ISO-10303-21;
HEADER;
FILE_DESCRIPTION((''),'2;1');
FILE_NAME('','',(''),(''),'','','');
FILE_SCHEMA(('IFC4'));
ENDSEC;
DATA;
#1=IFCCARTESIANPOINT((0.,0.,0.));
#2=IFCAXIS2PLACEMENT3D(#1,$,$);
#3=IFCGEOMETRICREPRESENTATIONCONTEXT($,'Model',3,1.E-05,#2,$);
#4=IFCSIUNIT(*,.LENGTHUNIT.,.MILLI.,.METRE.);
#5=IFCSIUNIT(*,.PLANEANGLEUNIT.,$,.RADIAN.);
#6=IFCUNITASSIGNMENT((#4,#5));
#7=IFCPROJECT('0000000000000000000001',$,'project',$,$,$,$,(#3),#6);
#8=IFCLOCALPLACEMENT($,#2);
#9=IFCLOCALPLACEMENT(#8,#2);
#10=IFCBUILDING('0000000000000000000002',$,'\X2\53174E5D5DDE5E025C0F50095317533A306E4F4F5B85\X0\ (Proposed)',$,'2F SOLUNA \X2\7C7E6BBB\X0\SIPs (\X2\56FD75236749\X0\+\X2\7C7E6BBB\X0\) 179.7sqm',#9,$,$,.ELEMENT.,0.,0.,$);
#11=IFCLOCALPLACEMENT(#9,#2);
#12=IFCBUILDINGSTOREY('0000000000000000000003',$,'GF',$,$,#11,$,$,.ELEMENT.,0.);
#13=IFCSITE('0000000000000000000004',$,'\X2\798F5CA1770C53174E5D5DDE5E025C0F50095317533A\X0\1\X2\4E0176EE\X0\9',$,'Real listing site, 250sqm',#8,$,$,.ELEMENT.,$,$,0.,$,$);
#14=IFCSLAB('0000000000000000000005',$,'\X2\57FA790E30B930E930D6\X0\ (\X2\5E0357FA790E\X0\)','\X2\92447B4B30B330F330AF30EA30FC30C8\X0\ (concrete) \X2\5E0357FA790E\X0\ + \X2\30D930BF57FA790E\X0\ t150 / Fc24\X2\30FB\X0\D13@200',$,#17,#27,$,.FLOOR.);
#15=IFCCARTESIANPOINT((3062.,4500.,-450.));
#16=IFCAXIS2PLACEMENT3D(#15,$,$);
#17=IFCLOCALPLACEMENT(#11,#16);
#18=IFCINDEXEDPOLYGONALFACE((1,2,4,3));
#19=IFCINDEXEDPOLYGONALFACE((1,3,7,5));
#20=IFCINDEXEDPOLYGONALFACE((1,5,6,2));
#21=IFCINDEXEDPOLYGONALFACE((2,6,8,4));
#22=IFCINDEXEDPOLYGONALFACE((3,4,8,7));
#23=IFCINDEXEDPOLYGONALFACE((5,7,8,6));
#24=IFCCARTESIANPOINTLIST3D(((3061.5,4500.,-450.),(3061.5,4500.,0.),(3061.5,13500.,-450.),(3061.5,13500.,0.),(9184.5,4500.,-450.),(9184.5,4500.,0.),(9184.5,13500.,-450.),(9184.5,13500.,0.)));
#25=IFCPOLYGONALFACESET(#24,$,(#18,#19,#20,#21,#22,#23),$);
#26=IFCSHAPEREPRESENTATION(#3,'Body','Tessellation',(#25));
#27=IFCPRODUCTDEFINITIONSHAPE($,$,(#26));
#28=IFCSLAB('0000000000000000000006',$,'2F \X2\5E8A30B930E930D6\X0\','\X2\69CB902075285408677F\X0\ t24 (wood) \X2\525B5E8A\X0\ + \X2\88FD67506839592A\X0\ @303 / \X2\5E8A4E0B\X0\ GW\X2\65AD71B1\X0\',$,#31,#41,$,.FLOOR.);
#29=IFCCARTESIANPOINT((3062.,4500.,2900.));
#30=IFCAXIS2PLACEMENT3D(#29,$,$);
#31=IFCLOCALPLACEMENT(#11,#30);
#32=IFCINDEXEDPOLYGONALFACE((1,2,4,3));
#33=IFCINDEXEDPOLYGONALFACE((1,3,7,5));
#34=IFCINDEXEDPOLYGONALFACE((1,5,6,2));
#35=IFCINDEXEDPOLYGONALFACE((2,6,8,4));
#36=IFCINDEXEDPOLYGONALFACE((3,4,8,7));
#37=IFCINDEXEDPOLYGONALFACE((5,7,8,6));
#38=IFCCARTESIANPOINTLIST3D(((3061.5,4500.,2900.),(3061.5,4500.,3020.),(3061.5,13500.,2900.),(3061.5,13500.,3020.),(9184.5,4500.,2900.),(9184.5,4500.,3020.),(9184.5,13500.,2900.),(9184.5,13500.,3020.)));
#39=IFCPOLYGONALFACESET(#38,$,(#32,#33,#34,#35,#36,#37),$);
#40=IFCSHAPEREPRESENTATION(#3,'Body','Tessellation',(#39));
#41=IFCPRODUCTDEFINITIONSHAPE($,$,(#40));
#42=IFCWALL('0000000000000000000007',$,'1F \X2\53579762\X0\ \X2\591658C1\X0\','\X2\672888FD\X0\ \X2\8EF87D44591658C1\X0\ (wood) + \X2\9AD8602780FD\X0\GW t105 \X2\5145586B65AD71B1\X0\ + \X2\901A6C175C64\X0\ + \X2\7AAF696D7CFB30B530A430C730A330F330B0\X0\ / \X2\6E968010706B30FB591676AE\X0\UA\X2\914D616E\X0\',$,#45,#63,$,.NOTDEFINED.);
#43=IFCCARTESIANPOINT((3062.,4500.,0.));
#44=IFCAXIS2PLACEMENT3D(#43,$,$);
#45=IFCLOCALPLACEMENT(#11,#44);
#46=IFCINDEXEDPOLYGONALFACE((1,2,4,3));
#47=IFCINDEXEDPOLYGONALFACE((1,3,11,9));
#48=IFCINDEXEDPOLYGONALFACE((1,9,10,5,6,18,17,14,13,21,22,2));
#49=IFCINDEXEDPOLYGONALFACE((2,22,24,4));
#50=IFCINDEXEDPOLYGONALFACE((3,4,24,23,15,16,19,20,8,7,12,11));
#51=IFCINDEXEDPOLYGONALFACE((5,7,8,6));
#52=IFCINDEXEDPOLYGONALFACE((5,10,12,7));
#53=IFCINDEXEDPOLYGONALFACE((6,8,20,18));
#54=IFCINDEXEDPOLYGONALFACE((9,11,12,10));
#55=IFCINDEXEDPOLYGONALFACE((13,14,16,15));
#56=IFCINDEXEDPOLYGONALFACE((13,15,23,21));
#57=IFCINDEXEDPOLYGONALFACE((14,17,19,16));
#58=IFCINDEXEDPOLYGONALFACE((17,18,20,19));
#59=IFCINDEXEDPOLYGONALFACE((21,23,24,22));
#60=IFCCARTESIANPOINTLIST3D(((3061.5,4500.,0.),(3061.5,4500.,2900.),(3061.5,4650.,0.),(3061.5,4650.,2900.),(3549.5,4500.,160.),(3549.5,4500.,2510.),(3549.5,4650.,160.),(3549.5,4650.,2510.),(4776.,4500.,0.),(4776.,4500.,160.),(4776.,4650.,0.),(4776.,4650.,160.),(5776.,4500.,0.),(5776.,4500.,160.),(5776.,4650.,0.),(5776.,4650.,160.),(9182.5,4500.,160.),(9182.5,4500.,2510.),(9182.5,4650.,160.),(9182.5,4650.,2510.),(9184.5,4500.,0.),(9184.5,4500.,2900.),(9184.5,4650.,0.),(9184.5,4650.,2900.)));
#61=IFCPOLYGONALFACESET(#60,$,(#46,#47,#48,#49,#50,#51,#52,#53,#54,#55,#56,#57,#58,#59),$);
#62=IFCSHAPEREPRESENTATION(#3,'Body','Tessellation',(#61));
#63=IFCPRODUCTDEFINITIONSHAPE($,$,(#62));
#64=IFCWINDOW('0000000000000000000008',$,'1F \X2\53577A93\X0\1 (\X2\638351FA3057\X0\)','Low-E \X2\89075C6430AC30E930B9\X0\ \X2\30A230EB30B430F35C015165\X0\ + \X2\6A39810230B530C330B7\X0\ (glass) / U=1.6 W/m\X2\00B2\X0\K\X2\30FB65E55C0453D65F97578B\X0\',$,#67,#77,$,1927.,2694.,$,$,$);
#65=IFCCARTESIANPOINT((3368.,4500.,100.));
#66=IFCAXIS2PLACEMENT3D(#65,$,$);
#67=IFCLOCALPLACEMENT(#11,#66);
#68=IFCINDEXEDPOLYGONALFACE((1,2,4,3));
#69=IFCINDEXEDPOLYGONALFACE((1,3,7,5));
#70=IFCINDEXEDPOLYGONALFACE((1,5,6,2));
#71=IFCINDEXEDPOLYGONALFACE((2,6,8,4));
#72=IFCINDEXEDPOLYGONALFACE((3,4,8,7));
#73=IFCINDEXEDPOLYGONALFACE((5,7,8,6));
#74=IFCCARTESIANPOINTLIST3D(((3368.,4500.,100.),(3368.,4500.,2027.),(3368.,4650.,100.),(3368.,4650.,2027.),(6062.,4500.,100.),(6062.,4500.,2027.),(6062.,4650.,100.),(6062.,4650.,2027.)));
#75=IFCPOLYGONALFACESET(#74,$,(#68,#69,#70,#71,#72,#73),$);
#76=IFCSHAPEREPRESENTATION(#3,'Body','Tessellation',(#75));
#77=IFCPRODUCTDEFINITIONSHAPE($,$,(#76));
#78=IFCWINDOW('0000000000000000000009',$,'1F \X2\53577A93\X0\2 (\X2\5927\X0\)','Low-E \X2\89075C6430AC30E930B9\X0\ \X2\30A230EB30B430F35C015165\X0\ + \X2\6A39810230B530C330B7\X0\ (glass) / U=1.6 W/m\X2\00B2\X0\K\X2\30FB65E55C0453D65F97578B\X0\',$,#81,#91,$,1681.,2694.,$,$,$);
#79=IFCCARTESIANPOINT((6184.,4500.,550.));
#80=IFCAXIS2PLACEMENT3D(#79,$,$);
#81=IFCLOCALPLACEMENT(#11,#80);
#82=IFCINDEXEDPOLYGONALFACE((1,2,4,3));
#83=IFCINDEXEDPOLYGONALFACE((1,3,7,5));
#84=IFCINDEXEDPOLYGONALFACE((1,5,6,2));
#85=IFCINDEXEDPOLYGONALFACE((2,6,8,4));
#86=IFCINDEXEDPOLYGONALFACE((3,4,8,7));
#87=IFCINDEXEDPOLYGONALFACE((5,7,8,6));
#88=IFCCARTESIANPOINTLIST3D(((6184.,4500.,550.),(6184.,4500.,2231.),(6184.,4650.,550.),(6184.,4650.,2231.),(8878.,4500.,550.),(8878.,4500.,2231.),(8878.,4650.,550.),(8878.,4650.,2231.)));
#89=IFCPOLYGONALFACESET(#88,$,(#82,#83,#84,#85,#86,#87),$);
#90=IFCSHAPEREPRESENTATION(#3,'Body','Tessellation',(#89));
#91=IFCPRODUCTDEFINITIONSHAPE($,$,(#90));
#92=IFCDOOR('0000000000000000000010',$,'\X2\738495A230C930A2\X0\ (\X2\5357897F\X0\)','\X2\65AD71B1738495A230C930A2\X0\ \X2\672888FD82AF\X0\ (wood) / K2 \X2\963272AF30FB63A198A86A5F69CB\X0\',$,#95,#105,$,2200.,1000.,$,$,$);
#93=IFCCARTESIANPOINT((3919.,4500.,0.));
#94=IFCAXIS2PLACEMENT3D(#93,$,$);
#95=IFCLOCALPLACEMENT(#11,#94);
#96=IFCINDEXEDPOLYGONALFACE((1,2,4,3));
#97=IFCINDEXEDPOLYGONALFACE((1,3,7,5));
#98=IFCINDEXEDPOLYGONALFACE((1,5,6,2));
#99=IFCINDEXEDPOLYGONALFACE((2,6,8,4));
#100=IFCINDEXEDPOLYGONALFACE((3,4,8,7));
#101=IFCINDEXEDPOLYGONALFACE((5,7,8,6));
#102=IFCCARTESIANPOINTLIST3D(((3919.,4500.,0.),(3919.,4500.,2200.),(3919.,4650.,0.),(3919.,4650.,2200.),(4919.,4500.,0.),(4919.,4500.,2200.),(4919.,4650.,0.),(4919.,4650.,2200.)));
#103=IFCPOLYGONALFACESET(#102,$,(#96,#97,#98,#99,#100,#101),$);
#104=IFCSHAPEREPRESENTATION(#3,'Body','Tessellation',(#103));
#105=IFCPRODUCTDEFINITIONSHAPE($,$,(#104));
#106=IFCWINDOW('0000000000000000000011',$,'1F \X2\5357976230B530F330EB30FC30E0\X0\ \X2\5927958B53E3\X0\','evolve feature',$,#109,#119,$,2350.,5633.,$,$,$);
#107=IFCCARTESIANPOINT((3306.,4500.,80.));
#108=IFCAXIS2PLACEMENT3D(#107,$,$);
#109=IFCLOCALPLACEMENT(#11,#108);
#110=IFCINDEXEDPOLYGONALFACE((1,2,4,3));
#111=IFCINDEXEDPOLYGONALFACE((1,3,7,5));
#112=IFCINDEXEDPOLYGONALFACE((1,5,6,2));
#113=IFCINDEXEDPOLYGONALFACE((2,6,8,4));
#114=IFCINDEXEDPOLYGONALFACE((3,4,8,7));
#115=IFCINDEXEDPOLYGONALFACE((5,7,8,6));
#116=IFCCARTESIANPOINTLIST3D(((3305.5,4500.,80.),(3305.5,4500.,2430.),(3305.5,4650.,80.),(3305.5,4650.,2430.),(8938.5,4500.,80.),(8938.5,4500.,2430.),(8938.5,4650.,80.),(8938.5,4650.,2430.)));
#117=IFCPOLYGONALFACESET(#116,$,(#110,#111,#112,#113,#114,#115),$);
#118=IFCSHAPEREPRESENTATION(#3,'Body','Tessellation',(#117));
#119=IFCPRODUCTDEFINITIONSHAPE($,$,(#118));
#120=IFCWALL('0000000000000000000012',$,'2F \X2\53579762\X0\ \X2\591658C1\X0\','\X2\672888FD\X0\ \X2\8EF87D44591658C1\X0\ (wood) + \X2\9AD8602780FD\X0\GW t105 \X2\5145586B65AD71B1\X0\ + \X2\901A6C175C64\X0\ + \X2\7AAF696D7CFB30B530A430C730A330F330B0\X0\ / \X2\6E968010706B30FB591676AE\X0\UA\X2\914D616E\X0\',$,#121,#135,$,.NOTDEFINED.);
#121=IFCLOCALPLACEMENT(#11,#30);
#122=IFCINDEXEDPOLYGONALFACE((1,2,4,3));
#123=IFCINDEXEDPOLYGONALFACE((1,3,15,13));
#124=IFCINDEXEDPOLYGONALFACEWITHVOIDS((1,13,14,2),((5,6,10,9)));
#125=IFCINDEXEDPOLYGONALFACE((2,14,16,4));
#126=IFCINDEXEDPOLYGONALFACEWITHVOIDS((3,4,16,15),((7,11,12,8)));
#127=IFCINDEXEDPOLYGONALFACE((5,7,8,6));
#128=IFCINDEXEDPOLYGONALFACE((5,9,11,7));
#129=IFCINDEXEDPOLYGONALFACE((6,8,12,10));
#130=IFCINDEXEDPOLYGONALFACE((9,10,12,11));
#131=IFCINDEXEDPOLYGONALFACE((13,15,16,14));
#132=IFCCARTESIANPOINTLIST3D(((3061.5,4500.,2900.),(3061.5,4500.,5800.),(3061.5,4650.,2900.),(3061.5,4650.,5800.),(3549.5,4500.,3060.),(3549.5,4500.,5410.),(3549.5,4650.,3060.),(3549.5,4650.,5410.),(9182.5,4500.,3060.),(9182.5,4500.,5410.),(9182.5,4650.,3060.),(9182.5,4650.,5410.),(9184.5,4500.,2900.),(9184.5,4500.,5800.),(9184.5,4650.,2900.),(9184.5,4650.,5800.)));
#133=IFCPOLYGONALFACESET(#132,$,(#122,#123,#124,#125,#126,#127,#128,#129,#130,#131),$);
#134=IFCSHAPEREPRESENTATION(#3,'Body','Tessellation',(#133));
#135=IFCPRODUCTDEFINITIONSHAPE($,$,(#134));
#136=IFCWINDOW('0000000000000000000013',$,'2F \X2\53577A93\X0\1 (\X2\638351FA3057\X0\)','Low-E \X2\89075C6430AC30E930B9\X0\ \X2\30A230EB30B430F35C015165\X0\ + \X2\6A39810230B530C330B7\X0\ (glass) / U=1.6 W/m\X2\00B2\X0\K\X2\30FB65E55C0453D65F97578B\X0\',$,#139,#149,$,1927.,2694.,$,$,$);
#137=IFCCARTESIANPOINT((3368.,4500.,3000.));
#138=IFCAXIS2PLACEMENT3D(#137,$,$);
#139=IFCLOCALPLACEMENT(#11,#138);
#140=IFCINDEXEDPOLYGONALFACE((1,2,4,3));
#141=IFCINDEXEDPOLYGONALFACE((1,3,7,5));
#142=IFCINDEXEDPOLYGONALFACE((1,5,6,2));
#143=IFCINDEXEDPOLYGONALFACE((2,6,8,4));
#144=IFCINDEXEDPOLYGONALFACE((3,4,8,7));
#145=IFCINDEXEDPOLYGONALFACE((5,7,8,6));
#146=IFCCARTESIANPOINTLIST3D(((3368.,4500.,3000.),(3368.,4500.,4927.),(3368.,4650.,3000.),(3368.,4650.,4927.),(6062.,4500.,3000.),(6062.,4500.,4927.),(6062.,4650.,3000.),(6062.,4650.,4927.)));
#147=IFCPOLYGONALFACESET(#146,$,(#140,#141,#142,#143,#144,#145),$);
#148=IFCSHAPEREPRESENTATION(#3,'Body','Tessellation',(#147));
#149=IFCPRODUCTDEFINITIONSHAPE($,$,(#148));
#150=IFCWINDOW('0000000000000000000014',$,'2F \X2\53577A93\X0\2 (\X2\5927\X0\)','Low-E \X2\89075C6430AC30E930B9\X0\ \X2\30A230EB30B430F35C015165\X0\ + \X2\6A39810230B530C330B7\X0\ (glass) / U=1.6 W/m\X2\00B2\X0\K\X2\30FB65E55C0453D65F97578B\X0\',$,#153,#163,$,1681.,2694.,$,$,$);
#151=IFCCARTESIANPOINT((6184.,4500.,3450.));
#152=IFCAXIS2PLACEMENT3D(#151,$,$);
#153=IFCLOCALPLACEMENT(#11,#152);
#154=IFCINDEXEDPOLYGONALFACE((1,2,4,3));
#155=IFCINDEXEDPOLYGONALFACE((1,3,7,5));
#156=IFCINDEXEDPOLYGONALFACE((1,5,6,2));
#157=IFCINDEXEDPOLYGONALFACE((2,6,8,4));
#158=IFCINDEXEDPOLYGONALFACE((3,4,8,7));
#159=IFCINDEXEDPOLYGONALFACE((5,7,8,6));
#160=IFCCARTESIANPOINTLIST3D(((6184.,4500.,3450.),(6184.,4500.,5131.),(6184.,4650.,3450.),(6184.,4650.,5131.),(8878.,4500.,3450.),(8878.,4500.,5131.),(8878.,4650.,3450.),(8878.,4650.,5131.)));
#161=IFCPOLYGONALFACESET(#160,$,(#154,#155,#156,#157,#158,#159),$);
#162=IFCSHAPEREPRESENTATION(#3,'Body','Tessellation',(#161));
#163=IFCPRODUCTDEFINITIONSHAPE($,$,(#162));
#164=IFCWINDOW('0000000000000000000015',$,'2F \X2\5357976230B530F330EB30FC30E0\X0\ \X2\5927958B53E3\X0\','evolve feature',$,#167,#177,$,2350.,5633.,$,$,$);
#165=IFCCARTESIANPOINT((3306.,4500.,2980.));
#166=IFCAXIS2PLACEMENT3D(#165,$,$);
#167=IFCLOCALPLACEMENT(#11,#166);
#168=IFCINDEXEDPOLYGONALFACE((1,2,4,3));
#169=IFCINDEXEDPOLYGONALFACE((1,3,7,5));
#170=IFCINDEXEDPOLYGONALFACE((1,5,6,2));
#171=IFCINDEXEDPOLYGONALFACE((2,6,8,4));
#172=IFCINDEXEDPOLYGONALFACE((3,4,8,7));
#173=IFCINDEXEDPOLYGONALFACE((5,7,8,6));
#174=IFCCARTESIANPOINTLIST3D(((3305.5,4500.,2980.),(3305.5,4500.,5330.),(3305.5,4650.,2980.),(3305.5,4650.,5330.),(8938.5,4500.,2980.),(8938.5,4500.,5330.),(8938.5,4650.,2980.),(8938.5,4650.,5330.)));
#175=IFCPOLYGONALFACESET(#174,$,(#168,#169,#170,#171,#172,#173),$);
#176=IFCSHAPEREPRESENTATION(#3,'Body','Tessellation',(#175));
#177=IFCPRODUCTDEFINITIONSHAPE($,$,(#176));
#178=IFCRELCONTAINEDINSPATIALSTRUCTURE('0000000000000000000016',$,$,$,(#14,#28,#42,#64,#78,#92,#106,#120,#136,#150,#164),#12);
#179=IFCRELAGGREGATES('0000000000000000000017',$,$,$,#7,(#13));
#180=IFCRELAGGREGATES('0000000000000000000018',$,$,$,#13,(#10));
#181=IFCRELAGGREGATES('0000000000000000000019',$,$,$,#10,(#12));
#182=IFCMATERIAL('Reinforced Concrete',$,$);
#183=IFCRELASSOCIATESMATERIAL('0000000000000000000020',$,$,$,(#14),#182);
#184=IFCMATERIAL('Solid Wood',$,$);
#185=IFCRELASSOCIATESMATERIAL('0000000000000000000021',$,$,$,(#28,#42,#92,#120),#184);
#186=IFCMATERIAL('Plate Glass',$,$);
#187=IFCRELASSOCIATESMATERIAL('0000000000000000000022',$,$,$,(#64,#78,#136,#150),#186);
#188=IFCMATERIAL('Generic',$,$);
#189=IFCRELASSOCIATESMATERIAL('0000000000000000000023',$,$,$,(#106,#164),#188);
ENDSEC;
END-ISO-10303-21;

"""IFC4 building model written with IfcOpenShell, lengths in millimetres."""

from ifc_helpers import new_model, si_unit, frame, frame_2d, origin, place, context, project, spatial, rectangle, extrude, material, element, fill, save


model = new_model("IFC4")

# Units and contexts
model_context = context("Model", 3, precision=1e-05, world=origin())
ifc_project = project(units=[si_unit("LENGTHUNIT", "METRE", prefix="MILLI"), si_unit("PLANEANGLEUNIT", "RADIAN")], contexts=[model_context])

# Site, building, storey
site_placement = place(None, origin())
site = spatial("IfcSite", under=ifc_project, at=site_placement, Name="福岡県北九州市小倉北区1丁目9", ObjectType="Real listing site, 250sqm", CompositionType="ELEMENT", RefElevation=0.0)
building_placement = place(site_placement, origin())
building = spatial("IfcBuilding", under=site, at=building_placement, Name="北九州市小倉北区の住宅 (Proposed)", ObjectType="2F SOLUNA 籾殻SIPs (国産杉+籾殻) 179.7sqm", CompositionType="ELEMENT", ElevationOfRefHeight=0.0, ElevationOfTerrain=0.0)
storey_placement = place(building_placement, origin())
storey = spatial("IfcBuildingStorey", under=building, at=storey_placement, Name="GF", CompositionType="ELEMENT", Elevation=0.0)

# Slabs
ifc_material_1 = material(Name="Reinforced Concrete")
slab_1_placement = place(storey_placement, frame((3062.0, 4500.0, -450.0)))
element("IfcSlab", 1, at=slab_1_placement, inside=storey, material=ifc_material_1, Name="基礎スラブ (布基礎)", Description="鉄筋コンクリート (concrete) 布基礎 + ベタ基礎 t150 / Fc24・D13@200", PredefinedType="FLOOR", context=model_context, shape_type="SweptSolid", body=[
    extrude(rectangle(XDim=6123.0, YDim=9000.0, at=frame_2d((3061.0, 4500.0))), frame((3062.0, 4500.0, -450.0)), (0.0, 0.0, 1.0), 450.0),
])
ifc_material_2 = material(Name="Solid Wood")
slab_2_placement = place(storey_placement, frame((3062.0, 4500.0, 2900.0)))
element("IfcSlab", 2, at=slab_2_placement, inside=storey, material=ifc_material_2, Name="2F 床スラブ", Description="構造用合板 t24 (wood) 剛床 + 製材根太 @303 / 床下 GW断熱", PredefinedType="FLOOR", context=model_context, shape_type="SweptSolid", body=[
    extrude(rectangle(XDim=6123.0, YDim=9000.0, at=frame_2d((3061.0, 4500.0))), frame((3062.0, 4500.0, 2900.0)), (0.0, 0.0, 1.0), 120.0),
])
ifc_material_3 = material(Name="Generic")

# Wall, openings, windows, door
wall_1_placement = place(storey_placement, frame((3062.0, 4500.0, 0.0)))
wall_1 = element("IfcWall", 3, at=wall_1_placement, inside=storey, material=ifc_material_2, Name="1F 南面 外壁", Description="木製 軸組外壁 (wood) + 高性能GW t105 充填断熱 + 通気層 + 窯業系サイディング / 準耐火・外皮UA配慮", PredefinedType="NOTDEFINED", context=model_context, shape_type="SweptSolid", body=[
    extrude(rectangle(XDim=6123.0, YDim=150.0, at=frame_2d((3061.0, 75.0))), frame((3062.0, 4500.0, 0.0)), (0.0, 0.0, 1.0), 2900.0),
])
opening_1_placement = place(storey_placement, frame((3368.0, 4500.0, 100.0)))
opening_1 = element("IfcOpeningElement", 4, at=opening_1_placement, cuts=wall_1, PredefinedType="NOTDEFINED", context=model_context, shape_type="SweptSolid", body=[
    extrude(rectangle(XDim=2694.0, YDim=150.0, at=frame_2d((1347.0, 75.0))), frame((3368.0, 4500.0, 100.0)), (0.0, 0.0, 1.0), 1927.0),
])
opening_2_placement = place(storey_placement, frame((6184.0, 4500.0, 550.0)))
opening_2 = element("IfcOpeningElement", 5, at=opening_2_placement, cuts=wall_1, PredefinedType="NOTDEFINED", context=model_context, shape_type="SweptSolid", body=[
    extrude(rectangle(XDim=2694.0, YDim=150.0, at=frame_2d((1347.0, 75.0))), frame((6184.0, 4500.0, 550.0)), (0.0, 0.0, 1.0), 1681.0),
])
opening_3_placement = place(storey_placement, frame((3919.0, 4500.0, 0.0)))
opening_3 = element("IfcOpeningElement", 6, at=opening_3_placement, cuts=wall_1, PredefinedType="NOTDEFINED", context=model_context, shape_type="SweptSolid", body=[
    extrude(rectangle(XDim=1000.0, YDim=150.0, at=frame_2d((500.0, 75.0))), frame((3919.0, 4500.0, 0.0)), (0.0, 0.0, 1.0), 2200.0),
])
opening_4_placement = place(storey_placement, frame((3306.0, 4500.0, 80.0)))
opening_4 = element("IfcOpeningElement", 7, at=opening_4_placement, cuts=wall_1, PredefinedType="NOTDEFINED", context=model_context, shape_type="SweptSolid", body=[
    extrude(rectangle(XDim=5633.0, YDim=150.0, at=frame_2d((2816.0, 75.0))), frame((3306.0, 4500.0, 80.0)), (0.0, 0.0, 1.0), 2350.0),
])
ifc_material_4 = material(Name="Plate Glass")
window_1_placement = place(storey_placement, frame((3368.0, 4500.0, 100.0)))
window_1 = element("IfcWindow", 8, at=window_1_placement, inside=storey, material=ifc_material_4, Name="1F 南窓1 (掃出し)", Description="Low-E 複層ガラス アルゴン封入 + 樹脂サッシ (glass) / U=1.6 W/m²K・日射取得型", OverallHeight=1927.0, OverallWidth=2694.0, context=model_context, shape_type="SweptSolid", body=[
    extrude(rectangle(XDim=2694.0, YDim=150.0, at=frame_2d((1347.0, 75.0))), frame((3368.0, 4500.0, 100.0)), (0.0, 0.0, 1.0), 1927.0),
])
fill(opening_1, window_1)
window_2_placement = place(storey_placement, frame((6184.0, 4500.0, 550.0)))
window_2 = element("IfcWindow", 9, at=window_2_placement, inside=storey, material=ifc_material_4, Name="1F 南窓2 (大)", Description="Low-E 複層ガラス アルゴン封入 + 樹脂サッシ (glass) / U=1.6 W/m²K・日射取得型", OverallHeight=1681.0, OverallWidth=2694.0, context=model_context, shape_type="SweptSolid", body=[
    extrude(rectangle(XDim=2694.0, YDim=150.0, at=frame_2d((1347.0, 75.0))), frame((6184.0, 4500.0, 550.0)), (0.0, 0.0, 1.0), 1681.0),
])
fill(opening_2, window_2)
door_placement = place(storey_placement, frame((3919.0, 4500.0, 0.0)))
door = element("IfcDoor", 10, at=door_placement, inside=storey, material=ifc_material_2, Name="玄関ドア (南西)", Description="断熱玄関ドア 木製芯 (wood) / K2 防犯・採風機構", OverallHeight=2200.0, OverallWidth=1000.0, context=model_context, shape_type="SweptSolid", body=[
    extrude(rectangle(XDim=1000.0, YDim=150.0, at=frame_2d((500.0, 75.0))), frame((3919.0, 4500.0, 0.0)), (0.0, 0.0, 1.0), 2200.0),
])
fill(opening_3, door)
window_3_placement = place(storey_placement, frame((3306.0, 4500.0, 80.0)))
window_3 = element("IfcWindow", 11, at=window_3_placement, inside=storey, material=ifc_material_3, Name="1F 南面サンルーム 大開口", Description="evolve feature", OverallHeight=2350.0, OverallWidth=5633.0, context=model_context, shape_type="SweptSolid", body=[
    extrude(rectangle(XDim=5633.0, YDim=150.0, at=frame_2d((2816.0, 75.0))), frame((3306.0, 4500.0, 80.0)), (0.0, 0.0, 1.0), 2350.0),
])
fill(opening_4, window_3)

# Wall, openings, windows
wall_2_placement = place(storey_placement, frame((3062.0, 4500.0, 2900.0)))
wall_2 = element("IfcWall", 12, at=wall_2_placement, inside=storey, material=ifc_material_2, Name="2F 南面 外壁", Description="木製 軸組外壁 (wood) + 高性能GW t105 充填断熱 + 通気層 + 窯業系サイディング / 準耐火・外皮UA配慮", PredefinedType="NOTDEFINED", context=model_context, shape_type="SweptSolid", body=[
    extrude(rectangle(XDim=6123.0, YDim=150.0, at=frame_2d((3061.0, 75.0))), frame((3062.0, 4500.0, 2900.0)), (0.0, 0.0, 1.0), 2900.0),
])
opening_5_placement = place(storey_placement, frame((3368.0, 4500.0, 3000.0)))
opening_5 = element("IfcOpeningElement", 13, at=opening_5_placement, cuts=wall_2, PredefinedType="NOTDEFINED", context=model_context, shape_type="SweptSolid", body=[
    extrude(rectangle(XDim=2694.0, YDim=150.0, at=frame_2d((1347.0, 75.0))), frame((3368.0, 4500.0, 3000.0)), (0.0, 0.0, 1.0), 1927.0),
])
opening_6_placement = place(storey_placement, frame((6184.0, 4500.0, 3450.0)))
opening_6 = element("IfcOpeningElement", 14, at=opening_6_placement, cuts=wall_2, PredefinedType="NOTDEFINED", context=model_context, shape_type="SweptSolid", body=[
    extrude(rectangle(XDim=2694.0, YDim=150.0, at=frame_2d((1347.0, 75.0))), frame((6184.0, 4500.0, 3450.0)), (0.0, 0.0, 1.0), 1681.0),
])
opening_7_placement = place(storey_placement, frame((3306.0, 4500.0, 2980.0)))
opening_7 = element("IfcOpeningElement", 15, at=opening_7_placement, cuts=wall_2, PredefinedType="NOTDEFINED", context=model_context, shape_type="SweptSolid", body=[
    extrude(rectangle(XDim=5633.0, YDim=150.0, at=frame_2d((2816.0, 75.0))), frame((3306.0, 4500.0, 2980.0)), (0.0, 0.0, 1.0), 2350.0),
])
window_4_placement = place(storey_placement, frame((3368.0, 4500.0, 3000.0)))
window_4 = element("IfcWindow", 16, at=window_4_placement, inside=storey, material=ifc_material_4, Name="2F 南窓1 (掃出し)", Description="Low-E 複層ガラス アルゴン封入 + 樹脂サッシ (glass) / U=1.6 W/m²K・日射取得型", OverallHeight=1927.0, OverallWidth=2694.0, context=model_context, shape_type="SweptSolid", body=[
    extrude(rectangle(XDim=2694.0, YDim=150.0, at=frame_2d((1347.0, 75.0))), frame((3368.0, 4500.0, 3000.0)), (0.0, 0.0, 1.0), 1927.0),
])
fill(opening_5, window_4)
window_5_placement = place(storey_placement, frame((6184.0, 4500.0, 3450.0)))
window_5 = element("IfcWindow", 17, at=window_5_placement, inside=storey, material=ifc_material_4, Name="2F 南窓2 (大)", Description="Low-E 複層ガラス アルゴン封入 + 樹脂サッシ (glass) / U=1.6 W/m²K・日射取得型", OverallHeight=1681.0, OverallWidth=2694.0, context=model_context, shape_type="SweptSolid", body=[
    extrude(rectangle(XDim=2694.0, YDim=150.0, at=frame_2d((1347.0, 75.0))), frame((6184.0, 4500.0, 3450.0)), (0.0, 0.0, 1.0), 1681.0),
])
fill(opening_6, window_5)
window_6_placement = place(storey_placement, frame((3306.0, 4500.0, 2980.0)))
window_6 = element("IfcWindow", 18, at=window_6_placement, inside=storey, material=ifc_material_3, Name="2F 南面サンルーム 大開口", Description="evolve feature", OverallHeight=2350.0, OverallWidth=5633.0, context=model_context, shape_type="SweptSolid", body=[
    extrude(rectangle(XDim=5633.0, YDim=150.0, at=frame_2d((2816.0, 75.0))), frame((3306.0, 4500.0, 2980.0)), (0.0, 0.0, 1.0), 2350.0),
])
fill(opening_7, window_6)

save(model, "model.ifc")
